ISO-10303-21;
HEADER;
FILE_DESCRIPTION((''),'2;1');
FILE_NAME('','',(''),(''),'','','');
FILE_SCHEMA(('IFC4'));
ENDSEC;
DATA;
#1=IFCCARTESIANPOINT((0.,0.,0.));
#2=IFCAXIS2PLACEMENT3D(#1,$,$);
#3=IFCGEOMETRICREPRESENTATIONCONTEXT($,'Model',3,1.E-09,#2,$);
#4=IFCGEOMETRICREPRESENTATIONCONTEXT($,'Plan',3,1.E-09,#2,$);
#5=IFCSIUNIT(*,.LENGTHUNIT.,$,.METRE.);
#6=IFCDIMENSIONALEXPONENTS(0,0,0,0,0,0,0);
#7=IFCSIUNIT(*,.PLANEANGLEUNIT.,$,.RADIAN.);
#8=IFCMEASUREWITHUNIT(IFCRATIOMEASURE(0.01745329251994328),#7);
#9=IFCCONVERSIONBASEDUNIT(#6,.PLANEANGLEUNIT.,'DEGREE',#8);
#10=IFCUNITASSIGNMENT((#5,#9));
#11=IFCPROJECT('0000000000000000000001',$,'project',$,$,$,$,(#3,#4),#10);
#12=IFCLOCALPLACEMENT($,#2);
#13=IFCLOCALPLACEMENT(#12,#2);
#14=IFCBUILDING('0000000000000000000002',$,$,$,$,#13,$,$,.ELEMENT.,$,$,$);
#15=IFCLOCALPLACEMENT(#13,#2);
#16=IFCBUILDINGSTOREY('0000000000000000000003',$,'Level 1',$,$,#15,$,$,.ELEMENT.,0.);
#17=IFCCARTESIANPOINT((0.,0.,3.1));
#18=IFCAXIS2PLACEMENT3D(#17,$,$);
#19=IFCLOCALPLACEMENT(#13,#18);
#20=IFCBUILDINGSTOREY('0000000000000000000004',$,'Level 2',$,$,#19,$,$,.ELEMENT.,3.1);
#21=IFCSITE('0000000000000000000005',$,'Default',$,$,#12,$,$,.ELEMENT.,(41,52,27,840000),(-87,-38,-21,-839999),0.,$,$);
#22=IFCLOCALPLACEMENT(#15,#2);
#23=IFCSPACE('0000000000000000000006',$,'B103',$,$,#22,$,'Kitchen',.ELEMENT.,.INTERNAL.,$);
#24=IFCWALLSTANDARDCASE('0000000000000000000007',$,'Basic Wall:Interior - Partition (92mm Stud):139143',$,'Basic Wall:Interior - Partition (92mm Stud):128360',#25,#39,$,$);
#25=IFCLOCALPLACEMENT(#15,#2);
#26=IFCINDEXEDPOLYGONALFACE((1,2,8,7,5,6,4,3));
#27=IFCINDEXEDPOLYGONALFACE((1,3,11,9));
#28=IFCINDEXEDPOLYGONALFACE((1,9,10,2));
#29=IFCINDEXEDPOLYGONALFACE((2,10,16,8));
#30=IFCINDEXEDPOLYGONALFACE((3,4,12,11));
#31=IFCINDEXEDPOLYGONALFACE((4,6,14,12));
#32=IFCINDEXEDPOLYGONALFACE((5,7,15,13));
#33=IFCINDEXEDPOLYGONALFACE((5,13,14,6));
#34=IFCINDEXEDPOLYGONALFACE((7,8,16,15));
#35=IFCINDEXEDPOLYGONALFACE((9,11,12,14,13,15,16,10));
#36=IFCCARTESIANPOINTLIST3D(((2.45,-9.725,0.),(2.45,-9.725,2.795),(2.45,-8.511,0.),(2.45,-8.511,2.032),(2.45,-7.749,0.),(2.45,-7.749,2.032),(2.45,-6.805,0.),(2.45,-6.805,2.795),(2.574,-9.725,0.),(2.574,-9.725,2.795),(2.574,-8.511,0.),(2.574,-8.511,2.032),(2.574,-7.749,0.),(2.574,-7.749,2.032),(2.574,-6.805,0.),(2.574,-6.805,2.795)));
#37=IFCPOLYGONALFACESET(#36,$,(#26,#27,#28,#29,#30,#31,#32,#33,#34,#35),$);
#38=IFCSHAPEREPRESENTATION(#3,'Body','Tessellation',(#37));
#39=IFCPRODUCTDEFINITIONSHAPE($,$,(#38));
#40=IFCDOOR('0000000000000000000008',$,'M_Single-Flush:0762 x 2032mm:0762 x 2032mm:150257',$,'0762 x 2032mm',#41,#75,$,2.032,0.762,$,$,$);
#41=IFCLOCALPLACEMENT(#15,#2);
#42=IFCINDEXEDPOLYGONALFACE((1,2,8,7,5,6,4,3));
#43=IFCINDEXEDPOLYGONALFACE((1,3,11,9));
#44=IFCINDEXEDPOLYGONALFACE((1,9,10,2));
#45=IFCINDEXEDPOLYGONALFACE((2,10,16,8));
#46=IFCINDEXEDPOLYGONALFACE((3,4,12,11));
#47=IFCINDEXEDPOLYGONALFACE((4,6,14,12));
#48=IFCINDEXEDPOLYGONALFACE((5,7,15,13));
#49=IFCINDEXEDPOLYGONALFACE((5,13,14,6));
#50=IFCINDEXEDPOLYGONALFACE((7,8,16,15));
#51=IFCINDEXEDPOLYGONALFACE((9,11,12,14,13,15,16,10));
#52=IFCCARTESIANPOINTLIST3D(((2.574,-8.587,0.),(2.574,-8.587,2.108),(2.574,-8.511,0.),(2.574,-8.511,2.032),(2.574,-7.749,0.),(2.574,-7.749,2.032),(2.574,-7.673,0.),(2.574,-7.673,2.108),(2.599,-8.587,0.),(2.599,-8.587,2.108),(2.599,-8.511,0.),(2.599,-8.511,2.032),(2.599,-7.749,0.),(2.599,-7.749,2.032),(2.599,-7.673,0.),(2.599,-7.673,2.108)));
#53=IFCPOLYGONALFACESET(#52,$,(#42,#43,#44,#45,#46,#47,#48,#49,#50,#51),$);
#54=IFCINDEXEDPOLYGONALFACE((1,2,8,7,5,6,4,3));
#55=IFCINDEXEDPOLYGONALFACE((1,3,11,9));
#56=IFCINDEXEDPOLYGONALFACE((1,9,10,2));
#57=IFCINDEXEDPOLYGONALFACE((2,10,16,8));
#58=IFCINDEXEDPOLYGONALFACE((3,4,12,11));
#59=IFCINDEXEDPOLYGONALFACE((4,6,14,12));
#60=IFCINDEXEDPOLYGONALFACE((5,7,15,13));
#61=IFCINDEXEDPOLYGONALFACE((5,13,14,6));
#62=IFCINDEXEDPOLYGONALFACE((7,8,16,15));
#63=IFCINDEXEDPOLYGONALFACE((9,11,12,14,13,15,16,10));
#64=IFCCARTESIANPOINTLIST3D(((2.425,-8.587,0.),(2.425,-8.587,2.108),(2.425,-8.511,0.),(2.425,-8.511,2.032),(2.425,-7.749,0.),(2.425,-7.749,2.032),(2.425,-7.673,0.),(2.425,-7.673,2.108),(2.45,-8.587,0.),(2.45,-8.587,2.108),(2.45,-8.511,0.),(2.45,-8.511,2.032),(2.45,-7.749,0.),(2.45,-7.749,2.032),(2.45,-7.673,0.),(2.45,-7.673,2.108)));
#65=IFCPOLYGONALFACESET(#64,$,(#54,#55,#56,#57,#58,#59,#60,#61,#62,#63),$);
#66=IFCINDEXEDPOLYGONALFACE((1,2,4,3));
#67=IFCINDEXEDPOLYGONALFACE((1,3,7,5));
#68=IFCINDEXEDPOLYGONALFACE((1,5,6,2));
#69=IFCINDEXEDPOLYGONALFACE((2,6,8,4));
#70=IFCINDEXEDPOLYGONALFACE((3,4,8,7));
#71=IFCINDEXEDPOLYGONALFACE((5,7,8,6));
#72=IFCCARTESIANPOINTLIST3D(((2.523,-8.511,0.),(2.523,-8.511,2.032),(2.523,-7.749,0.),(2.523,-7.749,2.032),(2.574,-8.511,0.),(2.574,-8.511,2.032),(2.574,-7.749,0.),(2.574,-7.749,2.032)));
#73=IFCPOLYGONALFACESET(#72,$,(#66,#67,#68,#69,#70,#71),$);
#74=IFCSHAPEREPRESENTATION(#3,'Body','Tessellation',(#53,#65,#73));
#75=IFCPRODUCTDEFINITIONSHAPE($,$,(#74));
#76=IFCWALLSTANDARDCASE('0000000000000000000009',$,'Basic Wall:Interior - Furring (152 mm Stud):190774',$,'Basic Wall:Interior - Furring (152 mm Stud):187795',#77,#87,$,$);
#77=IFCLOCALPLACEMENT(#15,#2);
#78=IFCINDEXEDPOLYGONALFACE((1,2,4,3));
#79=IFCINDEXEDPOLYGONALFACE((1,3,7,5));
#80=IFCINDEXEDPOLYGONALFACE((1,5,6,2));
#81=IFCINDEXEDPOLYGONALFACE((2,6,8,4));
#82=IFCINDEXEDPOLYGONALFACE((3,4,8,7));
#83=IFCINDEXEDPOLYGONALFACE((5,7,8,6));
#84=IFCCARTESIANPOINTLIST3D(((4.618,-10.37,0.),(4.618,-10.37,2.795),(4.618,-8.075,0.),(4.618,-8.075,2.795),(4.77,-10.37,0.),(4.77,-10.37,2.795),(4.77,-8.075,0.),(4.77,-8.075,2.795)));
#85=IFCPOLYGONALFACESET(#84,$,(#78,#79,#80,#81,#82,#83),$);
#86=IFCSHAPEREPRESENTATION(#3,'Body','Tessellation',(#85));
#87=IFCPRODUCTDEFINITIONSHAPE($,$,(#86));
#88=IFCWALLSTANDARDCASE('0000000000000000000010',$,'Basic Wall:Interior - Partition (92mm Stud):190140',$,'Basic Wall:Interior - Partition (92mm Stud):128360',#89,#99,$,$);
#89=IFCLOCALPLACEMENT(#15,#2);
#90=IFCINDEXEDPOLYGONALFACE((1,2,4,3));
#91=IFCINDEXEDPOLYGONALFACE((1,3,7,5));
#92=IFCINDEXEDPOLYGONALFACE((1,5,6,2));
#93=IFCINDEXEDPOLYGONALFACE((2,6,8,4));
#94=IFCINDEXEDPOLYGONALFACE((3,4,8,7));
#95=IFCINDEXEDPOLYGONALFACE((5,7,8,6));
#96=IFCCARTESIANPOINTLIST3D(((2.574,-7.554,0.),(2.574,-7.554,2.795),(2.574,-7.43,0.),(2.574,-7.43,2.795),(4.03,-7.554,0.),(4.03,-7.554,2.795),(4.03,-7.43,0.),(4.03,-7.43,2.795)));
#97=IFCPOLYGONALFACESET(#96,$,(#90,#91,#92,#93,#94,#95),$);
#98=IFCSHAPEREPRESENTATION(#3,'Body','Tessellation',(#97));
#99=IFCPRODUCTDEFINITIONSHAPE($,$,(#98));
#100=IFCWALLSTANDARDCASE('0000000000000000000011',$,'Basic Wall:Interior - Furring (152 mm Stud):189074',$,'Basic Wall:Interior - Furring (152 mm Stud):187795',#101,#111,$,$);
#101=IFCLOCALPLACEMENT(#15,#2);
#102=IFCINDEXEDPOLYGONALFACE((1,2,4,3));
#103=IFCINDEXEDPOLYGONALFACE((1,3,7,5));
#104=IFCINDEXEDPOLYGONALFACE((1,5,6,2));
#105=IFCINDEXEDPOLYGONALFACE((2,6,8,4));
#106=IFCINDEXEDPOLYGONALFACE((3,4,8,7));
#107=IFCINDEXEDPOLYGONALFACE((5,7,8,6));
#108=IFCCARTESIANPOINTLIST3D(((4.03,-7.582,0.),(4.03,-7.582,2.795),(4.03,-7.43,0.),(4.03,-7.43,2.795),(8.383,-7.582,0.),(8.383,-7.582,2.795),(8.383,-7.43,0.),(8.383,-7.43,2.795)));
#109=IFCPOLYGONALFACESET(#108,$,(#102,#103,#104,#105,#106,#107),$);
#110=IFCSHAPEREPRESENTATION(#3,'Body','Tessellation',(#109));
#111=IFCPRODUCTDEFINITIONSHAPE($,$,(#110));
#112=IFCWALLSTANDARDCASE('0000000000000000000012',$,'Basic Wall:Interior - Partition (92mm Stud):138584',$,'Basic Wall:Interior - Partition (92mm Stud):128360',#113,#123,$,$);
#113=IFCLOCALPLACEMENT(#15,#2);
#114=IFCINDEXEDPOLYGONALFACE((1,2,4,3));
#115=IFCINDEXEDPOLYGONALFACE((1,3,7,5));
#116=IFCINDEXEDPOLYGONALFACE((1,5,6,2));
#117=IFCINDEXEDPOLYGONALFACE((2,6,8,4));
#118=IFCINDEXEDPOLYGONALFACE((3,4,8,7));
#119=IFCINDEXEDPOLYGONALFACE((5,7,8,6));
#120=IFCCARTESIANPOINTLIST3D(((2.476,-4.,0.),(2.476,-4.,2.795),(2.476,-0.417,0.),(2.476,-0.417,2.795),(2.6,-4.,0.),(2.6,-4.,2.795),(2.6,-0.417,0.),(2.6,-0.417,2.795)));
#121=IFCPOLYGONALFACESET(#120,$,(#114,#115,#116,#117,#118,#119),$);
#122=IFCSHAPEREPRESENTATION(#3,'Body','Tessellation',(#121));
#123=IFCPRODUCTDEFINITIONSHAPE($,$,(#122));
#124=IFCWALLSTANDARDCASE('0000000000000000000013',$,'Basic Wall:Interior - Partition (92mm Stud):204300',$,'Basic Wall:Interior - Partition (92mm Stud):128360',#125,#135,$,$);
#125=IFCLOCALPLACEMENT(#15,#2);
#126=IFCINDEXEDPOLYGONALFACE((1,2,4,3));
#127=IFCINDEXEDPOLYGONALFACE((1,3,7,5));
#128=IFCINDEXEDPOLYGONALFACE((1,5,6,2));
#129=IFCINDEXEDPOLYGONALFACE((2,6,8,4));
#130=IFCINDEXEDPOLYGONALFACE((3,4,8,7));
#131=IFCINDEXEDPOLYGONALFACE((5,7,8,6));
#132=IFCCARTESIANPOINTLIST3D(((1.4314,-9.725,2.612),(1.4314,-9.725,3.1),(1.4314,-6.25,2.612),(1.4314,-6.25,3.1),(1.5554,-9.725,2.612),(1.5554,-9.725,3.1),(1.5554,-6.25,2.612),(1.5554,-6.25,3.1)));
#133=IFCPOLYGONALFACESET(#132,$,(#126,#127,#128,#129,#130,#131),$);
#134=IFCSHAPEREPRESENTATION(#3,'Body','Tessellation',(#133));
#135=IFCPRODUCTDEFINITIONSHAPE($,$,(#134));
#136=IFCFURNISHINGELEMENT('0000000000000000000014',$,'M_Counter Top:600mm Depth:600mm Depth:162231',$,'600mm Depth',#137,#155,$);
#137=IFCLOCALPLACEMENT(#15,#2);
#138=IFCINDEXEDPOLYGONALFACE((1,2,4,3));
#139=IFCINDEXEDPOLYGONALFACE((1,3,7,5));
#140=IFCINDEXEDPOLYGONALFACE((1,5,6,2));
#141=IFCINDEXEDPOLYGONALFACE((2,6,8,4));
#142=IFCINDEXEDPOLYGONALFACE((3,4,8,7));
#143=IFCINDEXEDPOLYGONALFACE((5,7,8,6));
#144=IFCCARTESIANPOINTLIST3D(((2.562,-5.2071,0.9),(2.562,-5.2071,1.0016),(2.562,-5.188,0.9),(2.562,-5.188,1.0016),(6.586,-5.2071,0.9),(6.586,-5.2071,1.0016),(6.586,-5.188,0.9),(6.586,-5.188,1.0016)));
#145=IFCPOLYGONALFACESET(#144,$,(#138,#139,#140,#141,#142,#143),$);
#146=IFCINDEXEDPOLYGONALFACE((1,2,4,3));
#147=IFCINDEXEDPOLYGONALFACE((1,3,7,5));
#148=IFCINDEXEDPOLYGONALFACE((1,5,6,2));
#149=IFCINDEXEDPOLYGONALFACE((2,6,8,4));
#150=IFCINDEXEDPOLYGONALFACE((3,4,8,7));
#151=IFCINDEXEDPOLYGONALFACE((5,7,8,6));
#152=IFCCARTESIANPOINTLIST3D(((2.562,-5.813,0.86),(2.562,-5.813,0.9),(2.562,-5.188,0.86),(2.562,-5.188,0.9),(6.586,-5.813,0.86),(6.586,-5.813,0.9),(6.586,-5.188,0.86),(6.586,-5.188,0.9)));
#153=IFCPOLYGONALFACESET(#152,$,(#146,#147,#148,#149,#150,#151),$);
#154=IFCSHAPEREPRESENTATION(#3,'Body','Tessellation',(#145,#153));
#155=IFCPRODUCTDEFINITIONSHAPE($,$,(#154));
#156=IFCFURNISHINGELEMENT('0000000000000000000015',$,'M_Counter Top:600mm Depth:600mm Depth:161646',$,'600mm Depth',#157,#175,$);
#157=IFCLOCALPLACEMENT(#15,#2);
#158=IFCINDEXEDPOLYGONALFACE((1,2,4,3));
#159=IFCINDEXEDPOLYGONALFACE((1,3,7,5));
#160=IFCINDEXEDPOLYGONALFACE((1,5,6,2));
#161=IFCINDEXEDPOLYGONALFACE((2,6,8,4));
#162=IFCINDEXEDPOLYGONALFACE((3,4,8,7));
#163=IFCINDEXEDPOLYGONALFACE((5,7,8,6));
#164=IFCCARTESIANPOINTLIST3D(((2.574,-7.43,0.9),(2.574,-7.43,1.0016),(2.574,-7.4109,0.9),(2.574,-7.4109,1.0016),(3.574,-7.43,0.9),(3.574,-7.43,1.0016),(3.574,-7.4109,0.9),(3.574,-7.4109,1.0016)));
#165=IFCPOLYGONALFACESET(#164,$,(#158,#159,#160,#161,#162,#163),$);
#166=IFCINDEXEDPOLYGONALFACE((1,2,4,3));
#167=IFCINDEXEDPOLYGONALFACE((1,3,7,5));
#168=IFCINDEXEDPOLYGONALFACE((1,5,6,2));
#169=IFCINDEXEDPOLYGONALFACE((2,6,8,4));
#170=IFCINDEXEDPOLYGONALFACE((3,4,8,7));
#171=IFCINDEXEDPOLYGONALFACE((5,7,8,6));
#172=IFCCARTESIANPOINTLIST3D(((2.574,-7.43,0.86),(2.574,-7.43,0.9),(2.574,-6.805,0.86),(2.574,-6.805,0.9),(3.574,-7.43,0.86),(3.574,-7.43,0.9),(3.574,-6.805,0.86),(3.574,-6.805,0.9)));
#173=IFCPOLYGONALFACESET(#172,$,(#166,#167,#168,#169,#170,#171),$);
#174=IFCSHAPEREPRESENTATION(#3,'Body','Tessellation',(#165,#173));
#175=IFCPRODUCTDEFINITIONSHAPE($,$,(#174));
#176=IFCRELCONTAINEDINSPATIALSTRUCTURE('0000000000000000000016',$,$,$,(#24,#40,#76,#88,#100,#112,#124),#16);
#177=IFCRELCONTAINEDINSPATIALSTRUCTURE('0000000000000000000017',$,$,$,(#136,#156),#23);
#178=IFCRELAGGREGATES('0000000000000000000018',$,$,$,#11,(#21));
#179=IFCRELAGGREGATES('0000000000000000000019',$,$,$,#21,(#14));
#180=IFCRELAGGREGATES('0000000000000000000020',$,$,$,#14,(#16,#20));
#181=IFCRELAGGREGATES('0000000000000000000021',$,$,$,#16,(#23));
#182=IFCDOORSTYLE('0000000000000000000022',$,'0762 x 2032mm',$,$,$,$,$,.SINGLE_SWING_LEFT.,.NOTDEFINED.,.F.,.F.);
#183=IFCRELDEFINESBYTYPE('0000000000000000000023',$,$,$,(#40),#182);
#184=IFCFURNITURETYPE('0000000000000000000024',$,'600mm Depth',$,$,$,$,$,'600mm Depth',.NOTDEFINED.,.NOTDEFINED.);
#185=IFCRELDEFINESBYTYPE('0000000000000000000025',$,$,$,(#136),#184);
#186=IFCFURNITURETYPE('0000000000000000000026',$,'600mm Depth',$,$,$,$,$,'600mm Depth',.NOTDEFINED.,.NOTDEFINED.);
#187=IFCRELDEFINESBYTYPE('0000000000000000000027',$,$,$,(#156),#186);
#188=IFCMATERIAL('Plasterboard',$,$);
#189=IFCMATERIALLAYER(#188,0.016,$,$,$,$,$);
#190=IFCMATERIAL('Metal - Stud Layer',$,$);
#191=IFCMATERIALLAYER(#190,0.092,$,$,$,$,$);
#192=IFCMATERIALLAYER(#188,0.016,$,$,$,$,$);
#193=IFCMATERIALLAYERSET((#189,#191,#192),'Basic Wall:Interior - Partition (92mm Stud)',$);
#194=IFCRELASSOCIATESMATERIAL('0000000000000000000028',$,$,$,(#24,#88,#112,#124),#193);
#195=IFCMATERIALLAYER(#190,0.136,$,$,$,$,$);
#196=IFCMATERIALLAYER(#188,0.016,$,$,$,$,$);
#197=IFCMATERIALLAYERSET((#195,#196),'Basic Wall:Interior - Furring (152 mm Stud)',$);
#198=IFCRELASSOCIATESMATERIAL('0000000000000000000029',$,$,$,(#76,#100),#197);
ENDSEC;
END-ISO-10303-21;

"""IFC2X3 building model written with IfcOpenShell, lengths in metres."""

from ifc_helpers import new_model, entity, si_unit, converted_unit, frame, frame_2d, origin, origin_2d_with_axis, place, context, project, spatial, polyline, rectangle, outline, extrude, clip, bounded_halfspace, source, transform, mapped, material, layer, layer_set, layer_usage, type_object, type_shapes, element, fill, save


model = new_model("IFC2X3")

# Units and contexts
model_context = context("Model", 3, precision=1e-09, world=origin())
plan_context = context("Plan", 3, precision=1e-09, world=origin())
ifc_project = project(units=[si_unit("LENGTHUNIT", "METRE"), converted_unit("PLANEANGLEUNIT", "DEGREE", entity("IfcRatioMeasure", 0.01745329251994328), si_unit("PLANEANGLEUNIT", "RADIAN"), dimensions=[0, 0, 0, 0, 0, 0, 0])], contexts=[model_context, plan_context])

# Site, building, storey
site_placement = place(None, origin())
site = spatial("IfcSite", under=ifc_project, at=site_placement, Name="Default", CompositionType="ELEMENT", RefLatitude=(41, 52, 27, 840000), RefLongitude=(-87, -38, -21, -839999), RefElevation=0.0)
building_placement = place(site_placement, origin())
building = spatial("IfcBuilding", under=site, at=building_placement, CompositionType="ELEMENT")
storey_1_placement = place(building_placement, origin())
storey_1 = spatial("IfcBuildingStorey", under=building, at=storey_1_placement, Name="Level 1", CompositionType="ELEMENT", Elevation=0.0)

# Shared definitions
ifc_material_1 = material(Name="Metal - Stud Layer")
ifc_material_2 = material(Name="Plasterboard")

# Shared definitions
ifc_layer_1 = layer(ifc_material_2, 0.016)
ifc_layer_2 = layer(ifc_material_1, 0.092)
ifc_layer_3 = layer(ifc_material_2, 0.016)
ifc_layer_set_1 = layer_set([ifc_layer_1, ifc_layer_2, ifc_layer_3], Name="Basic Wall:Interior - Partition (92mm Stud)")
ifc_layer_usage_1 = layer_usage(ifc_layer_set_1, "AXIS2", "NEGATIVE", 0.062)

# Shared definitions
storey_2_placement = place(building_placement, frame((0.0, 0.0, 3.1)))
storey_2 = spatial("IfcBuildingStorey", under=building, at=storey_2_placement, Name="Level 2", CompositionType="ELEMENT", Elevation=3.1)

# Wall, opening, door
wall_1_placement = place(storey_1_placement, frame((2.512, -6.805, 0.0), z_axis=(0.0, 0.0, 1.0), x_axis=(0.0, -1.0, 0.0)))
wall_1 = element("IfcWallStandardCase", 1, at=wall_1_placement, inside=storey_1, material=ifc_layer_usage_1, Name="Basic Wall:Interior - Partition (92mm Stud):139143", ObjectType="Basic Wall:Interior - Partition (92mm Stud):128360", context=model_context, shape_type="SweptSolid", body=[
    extrude(rectangle(XDim=2.92, YDim=0.124, at=frame_2d((1.46, 0.0), x_axis=(-1.0, 0.0))), origin(), (0.0, 0.0, 1.0), 2.795),
])
opening_1_placement = place(wall_1_placement, frame((0.944, -0.062, 0.0)))
opening_1 = element("IfcOpeningElement", 2, at=opening_1_placement, cuts=wall_1, ObjectType="Opening", context=model_context, shape_type="SweptSolid", body=[
    extrude(rectangle(XDim=0.762, YDim=2.032, at=frame_2d((1.016, 0.381), x_axis=(0.0, -1.0))), frame((0.0, 0.0, 0.0), z_axis=(0.0, 1.0, 0.0), x_axis=(0.0, 0.0, 1.0)), (0.0, 0.0, 1.0), 0.124),
])
door_style_1 = type_object("IfcDoorStyle", Name="0762 x 2032mm", ConstructionType="NOTDEFINED", OperationType="SINGLE_SWING_LEFT", ParameterTakesPrecedence=False, Sizeable=False)
shared_shape_1 = source(origin(), model_context, "Body", "SweptSolid", [
    extrude(outline(polyline([(-0.457, -1.073), (0.457, -1.073), (0.457, 1.035), (0.381, 1.035), (0.381, -0.997), (-0.381, -0.997), (-0.381, 1.035), (-0.457, 1.035), (-0.457, -1.073)])), frame((0.381, 0.149, 1.035), z_axis=(0.0, -1.0, 0.0), x_axis=(-1.0, 0.0, 0.0)), (0.0, 0.0, 1.0), 0.025),
    extrude(outline(polyline([(-1.073, -0.457), (1.035, -0.457), (1.035, -0.381), (-0.997, -0.381), (-0.997, 0.381), (1.035, 0.381), (1.035, 0.457), (-1.073, 0.457), (-1.073, -0.457)])), frame((0.381, 0.0, 1.035), z_axis=(0.0, -1.0, 0.0), x_axis=(0.0, 0.0, -1.0)), (0.0, 0.0, 1.0), 0.025),
    extrude(rectangle(XDim=0.762, YDim=0.051, at=origin_2d_with_axis()), frame((0.381, 0.0985, 0.0)), (0.0, 0.0, 1.0), 2.032),
])
type_shapes(door_style_1, [shared_shape_1])
door_1_placement = place(opening_1_placement, origin())
door_1 = element("IfcDoor", 3, at=door_1_placement, inside=storey_1, type_object=door_style_1, Name="M_Single-Flush:0762 x 2032mm:0762 x 2032mm:150257", ObjectType="0762 x 2032mm", OverallHeight=2.032, OverallWidth=0.762, context=model_context, shape_type="MappedRepresentation", body=[
    mapped(shared_shape_1, transform((0.0, 0.0, 0.0), scale=1.0)),
])
fill(opening_1, door_1)

# Walls
ifc_layer_4 = layer(ifc_material_1, 0.136)
ifc_layer_5 = layer(ifc_material_2, 0.016)
ifc_layer_set_2 = layer_set([ifc_layer_4, ifc_layer_5], Name="Basic Wall:Interior - Furring (152 mm Stud)")
ifc_layer_usage_2 = layer_usage(ifc_layer_set_2, "AXIS2", "POSITIVE", -0.076)
wall_2_placement = place(storey_1_placement, frame((4.694, -8.075, 0.0), z_axis=(0.0, 0.0, 1.0), x_axis=(0.0, -1.0, 0.0)))
element("IfcWallStandardCase", 4, at=wall_2_placement, inside=storey_1, material=ifc_layer_usage_2, Name="Basic Wall:Interior - Furring (152 mm Stud):190774", ObjectType="Basic Wall:Interior - Furring (152 mm Stud):187795", context=model_context, shape_type="SweptSolid", body=[
    extrude(rectangle(XDim=2.295, YDim=0.152, at=frame_2d((1.1475, 0.0), x_axis=(-1.0, 0.0))), origin(), (0.0, 0.0, 1.0), 2.795),
])
wall_3_placement = place(storey_1_placement, frame((4.03, -7.492, 0.0), z_axis=(0.0, 0.0, 1.0), x_axis=(-1.0, 0.0, 0.0)))
element("IfcWallStandardCase", 5, at=wall_3_placement, inside=storey_1, material=ifc_layer_usage_1, Name="Basic Wall:Interior - Partition (92mm Stud):190140", ObjectType="Basic Wall:Interior - Partition (92mm Stud):128360", context=model_context, shape_type="SweptSolid", body=[
    extrude(rectangle(XDim=1.456, YDim=0.124, at=frame_2d((0.728, 0.0), x_axis=(-1.0, 0.0))), origin(), (0.0, 0.0, 1.0), 2.795),
])
ifc_layer_usage_3 = layer_usage(ifc_layer_set_2, "AXIS2", "NEGATIVE", 0.076)
wall_4_placement = place(storey_1_placement, frame((8.383, -7.506, 0.0), z_axis=(0.0, 0.0, 1.0), x_axis=(-1.0, 0.0, 0.0)))
element("IfcWallStandardCase", 6, at=wall_4_placement, inside=storey_1, material=ifc_layer_usage_3, Name="Basic Wall:Interior - Furring (152 mm Stud):189074", ObjectType="Basic Wall:Interior - Furring (152 mm Stud):187795", context=model_context, shape_type="Clipping", body=[
    clip(extrude(rectangle(XDim=4.353, YDim=0.152, at=frame_2d((2.1765, 0.0), x_axis=(-1.0, 0.0))), origin(), (0.0, 0.0, 1.0), 2.795), bounded_halfspace(frame((0.0, -0.076, 2.795), z_axis=(0.0, 0.0, -1.0), x_axis=(0.0, 1.0, 0.0)), True, frame((0.0, -0.076, 2.795)), polyline([(0.0, 0.0), (3.708, 0.0), (3.708, 0.152), (0.0, 0.152), (0.0, 0.0)]))),
])
wall_5_placement = place(storey_1_placement, frame((2.538, -0.417, 0.0), z_axis=(0.0, 0.0, 1.0), x_axis=(0.0, -1.0, 0.0)))
element("IfcWallStandardCase", 7, at=wall_5_placement, inside=storey_1, material=ifc_layer_usage_1, Name="Basic Wall:Interior - Partition (92mm Stud):138584", ObjectType="Basic Wall:Interior - Partition (92mm Stud):128360", context=model_context, shape_type="SweptSolid", body=[
    extrude(rectangle(XDim=3.583, YDim=0.124, at=frame_2d((1.7915, 0.0), x_axis=(-1.0, 0.0))), origin(), (0.0, 0.0, 1.0), 2.795),
])
wall_6_placement = place(storey_1_placement, frame((1.4934, -6.25, 2.612), z_axis=(0.0, 0.0, 1.0), x_axis=(0.0, -1.0, 0.0)))
element("IfcWallStandardCase", 8, at=wall_6_placement, inside=storey_1, material=ifc_layer_usage_1, Name="Basic Wall:Interior - Partition (92mm Stud):204300", ObjectType="Basic Wall:Interior - Partition (92mm Stud):128360", context=model_context, shape_type="SweptSolid", body=[
    extrude(rectangle(XDim=3.475, YDim=0.124, at=frame_2d((1.7375, 0.0), x_axis=(-1.0, 0.0))), origin(), (0.0, 0.0, 1.0), 0.488),
])

# Shared definitions
space_1_placement = place(storey_1_placement, origin())
space_1 = spatial("IfcSpace", under=storey_1, at=space_1_placement, Name="B103", LongName="Kitchen", CompositionType="ELEMENT", InteriorOrExteriorSpace="INTERNAL")

# Furnishing elements
furniture_type_1 = type_object("IfcFurnitureType", Name="600mm Depth", ElementType="600mm Depth", AssemblyPlace="NOTDEFINED")
shared_shape_2 = source(origin(), model_context, "Body", "SweptSolid", [
    extrude(rectangle(XDim=0.0191, YDim=4.024, at=origin_2d_with_axis()), frame((0.8115, -0.0095, 0.9), z_axis=(0.0, 0.0, 1.0), x_axis=(0.0, -1.0, 0.0)), (0.0, 0.0, 1.0), 0.1016),
    extrude(rectangle(XDim=4.024, YDim=0.625, at=origin_2d_with_axis()), frame((0.8115, -0.3125, 0.86), z_axis=(0.0, 0.0, 1.0), x_axis=(-1.0, 0.0, 0.0)), (0.0, 0.0, 1.0), 0.04),
])
type_shapes(furniture_type_1, [shared_shape_2])
furnishing_1_placement = place(space_1_placement, frame((3.7625, -5.188, 0.0)))
element("IfcFurnishingElement", 9, at=furnishing_1_placement, inside=space_1, type_object=furniture_type_1, Name="M_Counter Top:600mm Depth:600mm Depth:162231", ObjectType="600mm Depth", context=model_context, shape_type="MappedRepresentation", body=[
    mapped(shared_shape_2, transform((0.0, 0.0, 0.0), scale=1.0)),
])
furniture_type_2 = type_object("IfcFurnitureType", Name="600mm Depth", ElementType="600mm Depth", AssemblyPlace="NOTDEFINED")
shared_shape_3 = source(origin(), model_context, "Body", "SweptSolid", [
    extrude(rectangle(XDim=0.0191, YDim=1.0, at=origin_2d_with_axis()), frame((-0.7005, -0.0095, 0.9), z_axis=(0.0, 0.0, 1.0), x_axis=(0.0, -1.0, 0.0)), (0.0, 0.0, 1.0), 0.1016),
    extrude(rectangle(XDim=1.0, YDim=0.625, at=origin_2d_with_axis()), frame((-0.7005, -0.3125, 0.86), z_axis=(0.0, 0.0, 1.0), x_axis=(-1.0, 0.0, 0.0)), (0.0, 0.0, 1.0), 0.04),
])
type_shapes(furniture_type_2, [shared_shape_3])
furnishing_2_placement = place(space_1_placement, frame((2.3735, -7.43, 0.0), z_axis=(0.0, 0.0, 1.0), x_axis=(-1.0, 0.0, 0.0)))
element("IfcFurnishingElement", 10, at=furnishing_2_placement, inside=space_1, type_object=furniture_type_2, Name="M_Counter Top:600mm Depth:600mm Depth:161646", ObjectType="600mm Depth", context=model_context, shape_type="MappedRepresentation", body=[
    mapped(shared_shape_3, transform((0.0, 0.0, 0.0), scale=1.0)),
])

save(model, "model.ifc")
